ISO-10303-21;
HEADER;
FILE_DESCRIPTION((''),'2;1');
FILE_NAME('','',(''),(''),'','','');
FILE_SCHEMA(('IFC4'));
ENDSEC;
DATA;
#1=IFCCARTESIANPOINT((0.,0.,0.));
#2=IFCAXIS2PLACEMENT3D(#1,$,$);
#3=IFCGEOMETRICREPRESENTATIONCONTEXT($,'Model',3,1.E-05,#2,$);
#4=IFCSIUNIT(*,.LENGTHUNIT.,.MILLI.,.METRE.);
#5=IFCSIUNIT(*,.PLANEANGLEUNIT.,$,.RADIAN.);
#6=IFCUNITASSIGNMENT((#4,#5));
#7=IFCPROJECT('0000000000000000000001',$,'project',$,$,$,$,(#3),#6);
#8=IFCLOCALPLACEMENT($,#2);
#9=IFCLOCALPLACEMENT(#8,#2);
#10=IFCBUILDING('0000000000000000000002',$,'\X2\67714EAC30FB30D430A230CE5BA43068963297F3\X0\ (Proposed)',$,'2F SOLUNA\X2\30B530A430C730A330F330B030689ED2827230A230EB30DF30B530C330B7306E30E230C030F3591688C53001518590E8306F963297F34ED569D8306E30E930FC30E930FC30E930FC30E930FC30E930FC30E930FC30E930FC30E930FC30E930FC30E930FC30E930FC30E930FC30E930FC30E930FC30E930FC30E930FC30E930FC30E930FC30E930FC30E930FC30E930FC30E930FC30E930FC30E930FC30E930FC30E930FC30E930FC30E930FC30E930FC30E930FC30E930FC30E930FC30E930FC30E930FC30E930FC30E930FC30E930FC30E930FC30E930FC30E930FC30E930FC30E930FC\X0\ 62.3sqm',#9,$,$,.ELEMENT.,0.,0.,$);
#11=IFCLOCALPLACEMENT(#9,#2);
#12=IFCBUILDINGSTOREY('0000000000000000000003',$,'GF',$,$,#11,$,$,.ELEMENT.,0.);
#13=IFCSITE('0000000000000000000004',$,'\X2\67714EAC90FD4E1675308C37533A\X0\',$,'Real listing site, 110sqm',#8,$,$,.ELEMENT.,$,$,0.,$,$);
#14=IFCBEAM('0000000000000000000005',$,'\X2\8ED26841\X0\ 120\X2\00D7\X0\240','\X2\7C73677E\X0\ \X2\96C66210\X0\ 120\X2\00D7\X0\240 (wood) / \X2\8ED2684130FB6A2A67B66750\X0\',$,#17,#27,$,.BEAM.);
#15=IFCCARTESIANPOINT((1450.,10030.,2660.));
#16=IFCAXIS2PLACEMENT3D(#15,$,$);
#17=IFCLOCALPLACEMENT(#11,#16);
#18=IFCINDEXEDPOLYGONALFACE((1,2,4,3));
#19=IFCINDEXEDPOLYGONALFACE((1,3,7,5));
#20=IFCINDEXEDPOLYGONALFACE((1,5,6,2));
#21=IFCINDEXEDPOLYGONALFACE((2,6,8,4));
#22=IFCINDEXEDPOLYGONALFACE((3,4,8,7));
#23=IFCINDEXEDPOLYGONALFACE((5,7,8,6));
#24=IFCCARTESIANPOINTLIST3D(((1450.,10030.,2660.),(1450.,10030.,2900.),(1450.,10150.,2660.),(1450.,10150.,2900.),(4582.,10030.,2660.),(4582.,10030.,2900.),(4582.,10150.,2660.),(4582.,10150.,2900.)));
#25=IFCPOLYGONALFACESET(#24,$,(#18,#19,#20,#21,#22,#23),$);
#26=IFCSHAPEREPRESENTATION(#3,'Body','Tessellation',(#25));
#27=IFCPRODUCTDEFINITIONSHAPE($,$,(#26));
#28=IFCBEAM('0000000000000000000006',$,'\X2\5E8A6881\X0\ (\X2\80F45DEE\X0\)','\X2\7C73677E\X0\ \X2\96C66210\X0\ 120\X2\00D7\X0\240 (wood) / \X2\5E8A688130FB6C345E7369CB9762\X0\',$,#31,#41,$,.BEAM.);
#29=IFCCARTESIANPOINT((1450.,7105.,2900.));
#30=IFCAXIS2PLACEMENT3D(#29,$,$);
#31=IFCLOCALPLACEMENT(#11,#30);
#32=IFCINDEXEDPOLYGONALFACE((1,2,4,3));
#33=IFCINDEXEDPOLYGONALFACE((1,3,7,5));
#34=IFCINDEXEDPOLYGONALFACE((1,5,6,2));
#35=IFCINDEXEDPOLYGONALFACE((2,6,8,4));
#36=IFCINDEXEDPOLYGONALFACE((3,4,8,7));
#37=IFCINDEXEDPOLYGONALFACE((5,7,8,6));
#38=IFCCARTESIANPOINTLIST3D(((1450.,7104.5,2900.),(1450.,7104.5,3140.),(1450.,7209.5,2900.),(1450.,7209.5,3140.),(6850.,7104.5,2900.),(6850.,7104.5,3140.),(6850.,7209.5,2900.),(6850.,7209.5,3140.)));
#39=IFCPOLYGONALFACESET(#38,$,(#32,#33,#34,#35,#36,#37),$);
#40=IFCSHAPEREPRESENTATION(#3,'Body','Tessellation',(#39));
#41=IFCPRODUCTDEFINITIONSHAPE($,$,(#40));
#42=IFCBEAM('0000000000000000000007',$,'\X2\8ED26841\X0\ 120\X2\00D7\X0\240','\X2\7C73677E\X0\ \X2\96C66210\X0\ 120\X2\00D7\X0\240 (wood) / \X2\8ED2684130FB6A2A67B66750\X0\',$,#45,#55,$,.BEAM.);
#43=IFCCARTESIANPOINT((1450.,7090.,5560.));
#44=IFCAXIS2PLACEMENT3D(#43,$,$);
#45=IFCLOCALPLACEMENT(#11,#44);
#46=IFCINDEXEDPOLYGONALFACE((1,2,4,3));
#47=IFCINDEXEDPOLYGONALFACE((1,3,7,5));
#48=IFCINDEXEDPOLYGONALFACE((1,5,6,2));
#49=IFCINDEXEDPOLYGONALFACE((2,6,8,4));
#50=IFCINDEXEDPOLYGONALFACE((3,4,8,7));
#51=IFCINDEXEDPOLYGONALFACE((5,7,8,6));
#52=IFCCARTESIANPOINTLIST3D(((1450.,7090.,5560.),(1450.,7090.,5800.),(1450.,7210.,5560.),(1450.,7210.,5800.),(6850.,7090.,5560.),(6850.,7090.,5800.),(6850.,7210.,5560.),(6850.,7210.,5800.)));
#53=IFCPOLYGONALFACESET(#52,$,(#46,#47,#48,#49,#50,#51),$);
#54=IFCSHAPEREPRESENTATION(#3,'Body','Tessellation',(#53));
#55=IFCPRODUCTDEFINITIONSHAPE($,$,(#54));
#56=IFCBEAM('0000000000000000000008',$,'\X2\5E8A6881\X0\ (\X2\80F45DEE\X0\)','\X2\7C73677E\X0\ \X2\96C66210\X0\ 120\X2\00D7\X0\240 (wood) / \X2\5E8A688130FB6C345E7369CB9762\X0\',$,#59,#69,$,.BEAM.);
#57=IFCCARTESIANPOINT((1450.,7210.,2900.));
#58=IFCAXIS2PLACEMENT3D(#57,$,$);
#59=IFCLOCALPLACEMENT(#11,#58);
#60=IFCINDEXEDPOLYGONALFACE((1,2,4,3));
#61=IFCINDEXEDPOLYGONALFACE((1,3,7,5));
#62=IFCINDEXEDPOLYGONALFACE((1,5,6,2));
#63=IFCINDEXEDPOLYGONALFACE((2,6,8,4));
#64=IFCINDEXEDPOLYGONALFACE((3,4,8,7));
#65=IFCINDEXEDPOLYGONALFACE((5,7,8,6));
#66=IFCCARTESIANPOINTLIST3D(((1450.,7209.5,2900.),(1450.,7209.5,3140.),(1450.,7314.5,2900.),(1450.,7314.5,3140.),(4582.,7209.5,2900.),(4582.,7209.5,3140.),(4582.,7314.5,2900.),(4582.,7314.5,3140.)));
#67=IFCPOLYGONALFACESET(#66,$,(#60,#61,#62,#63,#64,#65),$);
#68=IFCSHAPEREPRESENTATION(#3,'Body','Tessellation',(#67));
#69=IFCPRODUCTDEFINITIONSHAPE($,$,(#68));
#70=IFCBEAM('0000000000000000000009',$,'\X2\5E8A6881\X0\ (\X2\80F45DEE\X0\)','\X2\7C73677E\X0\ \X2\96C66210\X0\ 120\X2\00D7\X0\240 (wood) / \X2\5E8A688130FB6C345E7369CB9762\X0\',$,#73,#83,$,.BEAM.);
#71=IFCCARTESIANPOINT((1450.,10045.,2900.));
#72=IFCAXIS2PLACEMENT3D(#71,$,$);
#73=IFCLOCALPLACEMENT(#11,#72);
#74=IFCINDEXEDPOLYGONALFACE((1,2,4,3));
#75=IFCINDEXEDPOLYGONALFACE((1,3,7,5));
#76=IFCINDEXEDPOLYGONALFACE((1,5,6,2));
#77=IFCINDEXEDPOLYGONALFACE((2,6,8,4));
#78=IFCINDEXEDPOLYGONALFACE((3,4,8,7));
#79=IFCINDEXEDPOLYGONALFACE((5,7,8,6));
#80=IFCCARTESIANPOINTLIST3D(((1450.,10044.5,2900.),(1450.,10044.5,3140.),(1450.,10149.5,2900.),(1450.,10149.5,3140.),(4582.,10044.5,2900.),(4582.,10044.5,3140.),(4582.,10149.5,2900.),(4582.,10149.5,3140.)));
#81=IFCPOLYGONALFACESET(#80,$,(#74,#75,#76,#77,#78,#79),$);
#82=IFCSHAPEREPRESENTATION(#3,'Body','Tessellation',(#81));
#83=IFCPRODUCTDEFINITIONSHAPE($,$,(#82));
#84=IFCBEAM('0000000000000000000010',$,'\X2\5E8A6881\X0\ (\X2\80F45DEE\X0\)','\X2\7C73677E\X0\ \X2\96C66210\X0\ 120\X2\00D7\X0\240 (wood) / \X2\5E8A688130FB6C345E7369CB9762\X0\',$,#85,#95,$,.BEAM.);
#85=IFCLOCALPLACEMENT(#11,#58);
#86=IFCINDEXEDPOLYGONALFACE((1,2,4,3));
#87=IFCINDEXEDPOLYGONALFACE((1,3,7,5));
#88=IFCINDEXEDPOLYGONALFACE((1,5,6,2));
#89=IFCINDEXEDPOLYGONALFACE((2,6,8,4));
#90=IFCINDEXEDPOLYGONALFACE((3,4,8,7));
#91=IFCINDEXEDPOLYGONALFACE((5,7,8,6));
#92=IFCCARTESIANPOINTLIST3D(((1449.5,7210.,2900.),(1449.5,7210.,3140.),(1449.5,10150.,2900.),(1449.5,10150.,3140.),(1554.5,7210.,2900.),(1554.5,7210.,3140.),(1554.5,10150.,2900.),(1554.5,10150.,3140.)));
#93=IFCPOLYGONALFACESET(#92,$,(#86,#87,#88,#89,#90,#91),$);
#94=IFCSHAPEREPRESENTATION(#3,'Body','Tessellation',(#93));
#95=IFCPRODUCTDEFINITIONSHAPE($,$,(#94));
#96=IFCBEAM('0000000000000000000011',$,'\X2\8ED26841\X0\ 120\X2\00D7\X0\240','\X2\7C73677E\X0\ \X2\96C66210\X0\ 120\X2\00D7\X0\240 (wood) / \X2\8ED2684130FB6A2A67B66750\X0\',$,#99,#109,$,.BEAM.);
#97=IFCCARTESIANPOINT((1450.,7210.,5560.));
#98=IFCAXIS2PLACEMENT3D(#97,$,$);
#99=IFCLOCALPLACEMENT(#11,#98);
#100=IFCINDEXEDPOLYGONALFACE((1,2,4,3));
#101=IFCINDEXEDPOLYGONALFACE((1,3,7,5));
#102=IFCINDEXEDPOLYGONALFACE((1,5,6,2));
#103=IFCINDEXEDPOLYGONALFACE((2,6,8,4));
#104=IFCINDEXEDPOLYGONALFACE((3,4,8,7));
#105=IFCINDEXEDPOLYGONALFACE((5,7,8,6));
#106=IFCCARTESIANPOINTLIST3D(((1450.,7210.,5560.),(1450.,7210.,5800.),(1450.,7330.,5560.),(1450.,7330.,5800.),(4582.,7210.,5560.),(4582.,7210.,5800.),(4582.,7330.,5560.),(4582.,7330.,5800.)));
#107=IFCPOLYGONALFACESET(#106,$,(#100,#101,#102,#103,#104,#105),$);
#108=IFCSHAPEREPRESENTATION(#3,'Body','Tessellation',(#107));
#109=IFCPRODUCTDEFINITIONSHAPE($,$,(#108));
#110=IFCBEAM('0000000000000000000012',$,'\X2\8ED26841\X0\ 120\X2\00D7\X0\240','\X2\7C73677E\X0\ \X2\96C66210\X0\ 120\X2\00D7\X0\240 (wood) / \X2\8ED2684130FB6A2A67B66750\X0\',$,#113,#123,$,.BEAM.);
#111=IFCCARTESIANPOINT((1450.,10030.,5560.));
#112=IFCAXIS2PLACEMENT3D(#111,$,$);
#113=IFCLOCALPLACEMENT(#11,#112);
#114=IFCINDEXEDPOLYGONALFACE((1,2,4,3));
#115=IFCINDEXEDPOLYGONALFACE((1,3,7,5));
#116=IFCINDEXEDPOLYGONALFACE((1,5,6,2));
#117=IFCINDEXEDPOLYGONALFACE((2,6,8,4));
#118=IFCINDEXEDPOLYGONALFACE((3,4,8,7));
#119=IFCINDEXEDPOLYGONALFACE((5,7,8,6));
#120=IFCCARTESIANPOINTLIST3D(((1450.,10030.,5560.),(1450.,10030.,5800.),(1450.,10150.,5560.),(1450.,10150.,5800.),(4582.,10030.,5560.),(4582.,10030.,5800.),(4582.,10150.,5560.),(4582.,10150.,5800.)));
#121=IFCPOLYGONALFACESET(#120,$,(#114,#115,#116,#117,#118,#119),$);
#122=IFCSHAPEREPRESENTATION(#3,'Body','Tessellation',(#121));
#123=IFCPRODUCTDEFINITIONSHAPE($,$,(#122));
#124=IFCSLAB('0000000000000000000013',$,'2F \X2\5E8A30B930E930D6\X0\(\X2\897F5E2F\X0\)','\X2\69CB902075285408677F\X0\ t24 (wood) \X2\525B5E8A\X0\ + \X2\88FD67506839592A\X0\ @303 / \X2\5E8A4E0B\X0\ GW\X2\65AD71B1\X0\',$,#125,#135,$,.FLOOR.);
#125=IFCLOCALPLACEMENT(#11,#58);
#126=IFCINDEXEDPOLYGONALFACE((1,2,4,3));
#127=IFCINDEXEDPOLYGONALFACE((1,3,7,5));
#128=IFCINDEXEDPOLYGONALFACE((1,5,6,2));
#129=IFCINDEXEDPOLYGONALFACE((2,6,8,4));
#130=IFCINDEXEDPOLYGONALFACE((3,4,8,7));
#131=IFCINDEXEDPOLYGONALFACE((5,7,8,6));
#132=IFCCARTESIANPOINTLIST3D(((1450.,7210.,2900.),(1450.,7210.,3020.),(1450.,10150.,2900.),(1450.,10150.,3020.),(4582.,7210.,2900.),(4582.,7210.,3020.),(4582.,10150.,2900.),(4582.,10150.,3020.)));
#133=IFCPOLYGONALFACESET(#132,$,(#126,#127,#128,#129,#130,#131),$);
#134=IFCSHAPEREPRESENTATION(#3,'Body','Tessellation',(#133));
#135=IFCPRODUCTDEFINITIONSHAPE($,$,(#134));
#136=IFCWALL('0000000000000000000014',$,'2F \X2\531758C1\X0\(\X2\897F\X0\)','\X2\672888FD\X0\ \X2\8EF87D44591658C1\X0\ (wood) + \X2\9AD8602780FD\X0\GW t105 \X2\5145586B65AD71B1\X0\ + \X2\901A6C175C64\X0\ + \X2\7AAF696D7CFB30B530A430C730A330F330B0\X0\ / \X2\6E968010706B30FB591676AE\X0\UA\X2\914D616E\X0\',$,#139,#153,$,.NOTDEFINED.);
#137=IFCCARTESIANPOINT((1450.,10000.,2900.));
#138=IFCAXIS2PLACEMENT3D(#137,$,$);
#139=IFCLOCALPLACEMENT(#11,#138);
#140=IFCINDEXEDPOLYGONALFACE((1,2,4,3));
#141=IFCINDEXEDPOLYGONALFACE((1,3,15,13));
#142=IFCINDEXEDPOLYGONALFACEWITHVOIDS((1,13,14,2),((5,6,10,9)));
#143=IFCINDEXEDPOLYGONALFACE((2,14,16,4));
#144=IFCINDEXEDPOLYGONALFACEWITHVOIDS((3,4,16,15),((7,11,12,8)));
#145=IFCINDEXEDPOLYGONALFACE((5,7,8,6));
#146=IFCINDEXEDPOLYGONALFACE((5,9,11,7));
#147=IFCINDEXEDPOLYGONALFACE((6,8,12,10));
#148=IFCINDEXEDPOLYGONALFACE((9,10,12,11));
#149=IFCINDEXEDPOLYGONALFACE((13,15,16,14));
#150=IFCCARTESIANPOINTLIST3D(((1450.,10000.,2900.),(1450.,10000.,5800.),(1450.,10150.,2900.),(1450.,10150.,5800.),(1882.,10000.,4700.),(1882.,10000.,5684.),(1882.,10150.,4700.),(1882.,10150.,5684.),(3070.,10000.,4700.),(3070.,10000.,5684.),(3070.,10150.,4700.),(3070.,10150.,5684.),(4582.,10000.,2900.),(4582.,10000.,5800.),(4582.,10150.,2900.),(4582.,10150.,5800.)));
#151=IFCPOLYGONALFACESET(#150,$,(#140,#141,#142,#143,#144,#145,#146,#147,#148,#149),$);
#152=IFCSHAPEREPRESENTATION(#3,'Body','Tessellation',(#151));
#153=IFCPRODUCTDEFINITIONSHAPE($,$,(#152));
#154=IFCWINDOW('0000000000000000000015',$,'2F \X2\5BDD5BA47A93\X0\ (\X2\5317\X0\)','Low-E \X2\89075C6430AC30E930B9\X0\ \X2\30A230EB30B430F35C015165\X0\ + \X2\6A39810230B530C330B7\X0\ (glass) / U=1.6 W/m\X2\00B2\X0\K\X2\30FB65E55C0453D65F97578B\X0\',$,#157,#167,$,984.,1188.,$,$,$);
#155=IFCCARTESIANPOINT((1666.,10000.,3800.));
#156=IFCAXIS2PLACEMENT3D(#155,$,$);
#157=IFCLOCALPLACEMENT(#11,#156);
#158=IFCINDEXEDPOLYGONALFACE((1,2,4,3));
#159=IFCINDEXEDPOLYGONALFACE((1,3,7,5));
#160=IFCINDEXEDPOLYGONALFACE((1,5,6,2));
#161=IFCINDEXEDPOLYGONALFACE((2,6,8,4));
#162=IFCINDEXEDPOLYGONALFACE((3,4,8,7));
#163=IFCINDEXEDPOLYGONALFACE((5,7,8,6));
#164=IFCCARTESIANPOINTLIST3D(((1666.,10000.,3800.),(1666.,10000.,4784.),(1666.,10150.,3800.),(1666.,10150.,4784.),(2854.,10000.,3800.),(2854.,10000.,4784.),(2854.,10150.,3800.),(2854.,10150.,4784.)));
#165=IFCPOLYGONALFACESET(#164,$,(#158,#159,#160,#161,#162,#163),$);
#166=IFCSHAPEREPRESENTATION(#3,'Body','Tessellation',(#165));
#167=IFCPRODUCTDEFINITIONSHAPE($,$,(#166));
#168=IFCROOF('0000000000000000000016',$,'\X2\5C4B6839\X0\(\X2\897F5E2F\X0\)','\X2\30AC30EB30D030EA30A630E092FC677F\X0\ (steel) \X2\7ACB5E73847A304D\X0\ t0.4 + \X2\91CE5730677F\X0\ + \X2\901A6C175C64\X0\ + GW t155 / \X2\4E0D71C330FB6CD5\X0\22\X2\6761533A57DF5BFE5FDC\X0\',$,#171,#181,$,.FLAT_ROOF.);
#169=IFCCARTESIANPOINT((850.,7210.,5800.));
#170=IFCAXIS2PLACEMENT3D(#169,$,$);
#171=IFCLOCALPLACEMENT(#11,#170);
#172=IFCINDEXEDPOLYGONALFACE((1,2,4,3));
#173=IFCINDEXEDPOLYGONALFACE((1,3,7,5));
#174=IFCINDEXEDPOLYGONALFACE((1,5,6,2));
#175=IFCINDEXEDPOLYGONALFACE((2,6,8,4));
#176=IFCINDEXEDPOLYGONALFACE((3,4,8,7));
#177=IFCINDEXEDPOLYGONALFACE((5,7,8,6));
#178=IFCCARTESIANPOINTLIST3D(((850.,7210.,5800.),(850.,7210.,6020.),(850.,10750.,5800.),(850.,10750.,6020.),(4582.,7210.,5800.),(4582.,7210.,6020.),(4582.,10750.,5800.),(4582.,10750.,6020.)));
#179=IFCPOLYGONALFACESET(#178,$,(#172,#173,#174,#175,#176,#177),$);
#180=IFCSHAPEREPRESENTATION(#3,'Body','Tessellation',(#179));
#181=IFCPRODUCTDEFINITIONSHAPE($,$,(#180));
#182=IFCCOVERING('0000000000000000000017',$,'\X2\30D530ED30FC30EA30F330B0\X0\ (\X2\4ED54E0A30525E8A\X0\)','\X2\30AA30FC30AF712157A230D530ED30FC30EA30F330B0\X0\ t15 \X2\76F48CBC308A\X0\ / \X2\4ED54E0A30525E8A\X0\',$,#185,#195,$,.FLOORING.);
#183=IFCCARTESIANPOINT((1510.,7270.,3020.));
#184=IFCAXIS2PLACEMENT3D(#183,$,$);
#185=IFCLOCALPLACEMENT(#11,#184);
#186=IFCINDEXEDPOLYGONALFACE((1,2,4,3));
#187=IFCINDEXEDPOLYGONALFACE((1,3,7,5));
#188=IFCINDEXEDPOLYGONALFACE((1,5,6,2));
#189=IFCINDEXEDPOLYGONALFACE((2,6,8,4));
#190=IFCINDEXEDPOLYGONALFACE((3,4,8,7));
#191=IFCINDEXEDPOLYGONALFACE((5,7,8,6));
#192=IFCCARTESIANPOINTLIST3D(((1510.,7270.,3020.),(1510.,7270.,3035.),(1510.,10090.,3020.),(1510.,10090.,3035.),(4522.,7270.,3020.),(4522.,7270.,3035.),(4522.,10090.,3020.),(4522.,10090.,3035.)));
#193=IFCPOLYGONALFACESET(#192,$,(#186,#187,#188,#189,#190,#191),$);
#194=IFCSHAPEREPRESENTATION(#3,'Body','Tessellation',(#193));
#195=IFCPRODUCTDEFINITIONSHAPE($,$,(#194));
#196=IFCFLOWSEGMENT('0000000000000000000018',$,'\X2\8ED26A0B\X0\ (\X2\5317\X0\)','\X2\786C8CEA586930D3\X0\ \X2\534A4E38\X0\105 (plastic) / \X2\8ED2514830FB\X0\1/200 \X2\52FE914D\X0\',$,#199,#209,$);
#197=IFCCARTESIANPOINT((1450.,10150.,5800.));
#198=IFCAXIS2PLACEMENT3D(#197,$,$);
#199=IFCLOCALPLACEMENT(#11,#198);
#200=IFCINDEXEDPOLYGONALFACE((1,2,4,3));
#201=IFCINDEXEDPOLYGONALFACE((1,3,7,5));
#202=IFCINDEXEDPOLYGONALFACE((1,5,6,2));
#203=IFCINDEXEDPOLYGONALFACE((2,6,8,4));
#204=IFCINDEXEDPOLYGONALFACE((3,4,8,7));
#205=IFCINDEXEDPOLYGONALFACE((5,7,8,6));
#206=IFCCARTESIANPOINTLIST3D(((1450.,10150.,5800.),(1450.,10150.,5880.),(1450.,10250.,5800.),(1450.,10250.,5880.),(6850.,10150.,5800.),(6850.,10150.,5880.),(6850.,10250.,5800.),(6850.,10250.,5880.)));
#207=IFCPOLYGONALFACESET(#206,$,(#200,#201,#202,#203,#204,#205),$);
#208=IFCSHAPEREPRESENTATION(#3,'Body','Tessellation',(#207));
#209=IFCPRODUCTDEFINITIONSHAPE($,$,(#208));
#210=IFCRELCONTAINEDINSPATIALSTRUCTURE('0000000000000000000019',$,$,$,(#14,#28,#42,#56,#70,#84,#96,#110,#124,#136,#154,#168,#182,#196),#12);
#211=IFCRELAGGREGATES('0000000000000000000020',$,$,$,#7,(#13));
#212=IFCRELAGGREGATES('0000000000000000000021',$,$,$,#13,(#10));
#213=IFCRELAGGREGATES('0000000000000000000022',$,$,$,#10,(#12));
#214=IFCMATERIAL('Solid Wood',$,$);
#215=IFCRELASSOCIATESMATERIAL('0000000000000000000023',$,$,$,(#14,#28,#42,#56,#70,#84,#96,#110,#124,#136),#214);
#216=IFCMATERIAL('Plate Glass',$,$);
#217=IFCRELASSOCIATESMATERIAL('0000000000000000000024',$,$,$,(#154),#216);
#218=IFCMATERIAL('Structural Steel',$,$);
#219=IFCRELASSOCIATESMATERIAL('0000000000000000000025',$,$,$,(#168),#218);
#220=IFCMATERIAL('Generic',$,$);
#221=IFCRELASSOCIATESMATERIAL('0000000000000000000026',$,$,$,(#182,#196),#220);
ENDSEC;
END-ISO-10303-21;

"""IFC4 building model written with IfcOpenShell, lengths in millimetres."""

from ifc_helpers import new_model, si_unit, frame, frame_2d, origin, place, context, project, spatial, rectangle, extrude, material, element, fill, save


model = new_model("IFC4")

# Units and contexts
model_context = context("Model", 3, precision=1e-05, world=origin())
ifc_project = project(units=[si_unit("LENGTHUNIT", "METRE", prefix="MILLI"), si_unit("PLANEANGLEUNIT", "RADIAN")], contexts=[model_context])

# Site, building, storey
site_placement = place(None, origin())
site = spatial("IfcSite", under=ifc_project, at=site_placement, Name="東京都世田谷区", ObjectType="Real listing site, 110sqm", CompositionType="ELEMENT", RefElevation=0.0)
building_placement = place(site_placement, origin())
building = spatial("IfcBuilding", under=site, at=building_placement, Name="東京・ピアノ室と防音 (Proposed)", ObjectType="2F SOLUNAサイディングと黒色アルミサッシのモダン外装、内部は防音仕様のラーラーラーラーラーラーラーラーラーラーラーラーラーラーラーラーラーラーラーラーラーラーラーラーラーラーラーラーラーラーラーラーラーラーラーラーラーラーラーラーラーラー 62.3sqm", CompositionType="ELEMENT", ElevationOfRefHeight=0.0, ElevationOfTerrain=0.0)
storey_placement = place(building_placement, origin())
storey = spatial("IfcBuildingStorey", under=building, at=storey_placement, Name="GF", CompositionType="ELEMENT", Elevation=0.0)

# Shared definitions
ifc_material_1 = material(Name="Solid Wood")

# Beams
beam_1_placement = place(storey_placement, frame((1450.0, 10030.0, 2660.0)))
element("IfcBeam", 1, at=beam_1_placement, inside=storey, material=ifc_material_1, Name="軒桁 120×240", Description="米松 集成 120×240 (wood) / 軒桁・横架材", PredefinedType="BEAM", context=model_context, shape_type="SweptSolid", body=[
    extrude(rectangle(XDim=3132.0, YDim=120.0, at=frame_2d((1566.0, 60.0))), frame((1450.0, 10030.0, 2660.0)), (0.0, 0.0, 1.0), 240.0),
])
beam_2_placement = place(storey_placement, frame((1450.0, 7105.0, 2900.0)))
element("IfcBeam", 2, at=beam_2_placement, inside=storey, material=ifc_material_1, Name="床梁 (胴差)", Description="米松 集成 120×240 (wood) / 床梁・水平構面", PredefinedType="BEAM", context=model_context, shape_type="SweptSolid", body=[
    extrude(rectangle(XDim=5400.0, YDim=105.0, at=frame_2d((2700.0, 52.0))), frame((1450.0, 7105.0, 2900.0)), (0.0, 0.0, 1.0), 240.0),
])
beam_3_placement = place(storey_placement, frame((1450.0, 7090.0, 5560.0)))
element("IfcBeam", 3, at=beam_3_placement, inside=storey, material=ifc_material_1, Name="軒桁 120×240", Description="米松 集成 120×240 (wood) / 軒桁・横架材", PredefinedType="BEAM", context=model_context, shape_type="SweptSolid", body=[
    extrude(rectangle(XDim=5400.0, YDim=120.0, at=frame_2d((2700.0, 60.0))), frame((1450.0, 7090.0, 5560.0)), (0.0, 0.0, 1.0), 240.0),
])
beam_4_placement = place(storey_placement, frame((1450.0, 7210.0, 2900.0)))
element("IfcBeam", 4, at=beam_4_placement, inside=storey, material=ifc_material_1, Name="床梁 (胴差)", Description="米松 集成 120×240 (wood) / 床梁・水平構面", PredefinedType="BEAM", context=model_context, shape_type="SweptSolid", body=[
    extrude(rectangle(XDim=3132.0, YDim=105.0, at=frame_2d((1566.0, 52.0))), frame((1450.0, 7210.0, 2900.0)), (0.0, 0.0, 1.0), 240.0),
])
beam_5_placement = place(storey_placement, frame((1450.0, 10045.0, 2900.0)))
element("IfcBeam", 5, at=beam_5_placement, inside=storey, material=ifc_material_1, Name="床梁 (胴差)", Description="米松 集成 120×240 (wood) / 床梁・水平構面", PredefinedType="BEAM", context=model_context, shape_type="SweptSolid", body=[
    extrude(rectangle(XDim=3132.0, YDim=105.0, at=frame_2d((1566.0, 52.0))), frame((1450.0, 10045.0, 2900.0)), (0.0, 0.0, 1.0), 240.0),
])
beam_6_placement = place(storey_placement, frame((1450.0, 7210.0, 2900.0)))
element("IfcBeam", 6, at=beam_6_placement, inside=storey, material=ifc_material_1, Name="床梁 (胴差)", Description="米松 集成 120×240 (wood) / 床梁・水平構面", PredefinedType="BEAM", context=model_context, shape_type="SweptSolid", body=[
    extrude(rectangle(XDim=105.0, YDim=2940.0, at=frame_2d((52.0, 1470.0))), frame((1450.0, 7210.0, 2900.0)), (0.0, 0.0, 1.0), 240.0),
])
beam_7_placement = place(storey_placement, frame((1450.0, 7210.0, 5560.0)))
element("IfcBeam", 7, at=beam_7_placement, inside=storey, material=ifc_material_1, Name="軒桁 120×240", Description="米松 集成 120×240 (wood) / 軒桁・横架材", PredefinedType="BEAM", context=model_context, shape_type="SweptSolid", body=[
    extrude(rectangle(XDim=3132.0, YDim=120.0, at=frame_2d((1566.0, 60.0))), frame((1450.0, 7210.0, 5560.0)), (0.0, 0.0, 1.0), 240.0),
])
beam_8_placement = place(storey_placement, frame((1450.0, 10030.0, 5560.0)))
element("IfcBeam", 8, at=beam_8_placement, inside=storey, material=ifc_material_1, Name="軒桁 120×240", Description="米松 集成 120×240 (wood) / 軒桁・横架材", PredefinedType="BEAM", context=model_context, shape_type="SweptSolid", body=[
    extrude(rectangle(XDim=3132.0, YDim=120.0, at=frame_2d((1566.0, 60.0))), frame((1450.0, 10030.0, 5560.0)), (0.0, 0.0, 1.0), 240.0),
])

# Slab
slab_placement = place(storey_placement, frame((1450.0, 7210.0, 2900.0)))
element("IfcSlab", 9, at=slab_placement, inside=storey, material=ifc_material_1, Name="2F 床スラブ(西帯)", Description="構造用合板 t24 (wood) 剛床 + 製材根太 @303 / 床下 GW断熱", PredefinedType="FLOOR", context=model_context, shape_type="SweptSolid", body=[
    extrude(rectangle(XDim=3132.0, YDim=2940.0, at=frame_2d((1566.0, 1470.0))), frame((1450.0, 7210.0, 2900.0)), (0.0, 0.0, 1.0), 120.0),
])

# Wall, opening, window
wall_1_placement = place(storey_placement, frame((1450.0, 10000.0, 2900.0)))
wall_1 = element("IfcWall", 10, at=wall_1_placement, inside=storey, material=ifc_material_1, Name="2F 北壁(西)", Description="木製 軸組外壁 (wood) + 高性能GW t105 充填断熱 + 通気層 + 窯業系サイディング / 準耐火・外皮UA配慮", PredefinedType="NOTDEFINED", context=model_context, shape_type="SweptSolid", body=[
    extrude(rectangle(XDim=3132.0, YDim=150.0, at=frame_2d((1566.0, 75.0))), frame((1450.0, 10000.0, 2900.0)), (0.0, 0.0, 1.0), 2900.0),
])
opening_placement = place(storey_placement, frame((1666.0, 10000.0, 3800.0)))
opening = element("IfcOpeningElement", 11, at=opening_placement, cuts=wall_1, PredefinedType="NOTDEFINED", context=model_context, shape_type="SweptSolid", body=[
    extrude(rectangle(XDim=1188.0, YDim=150.0, at=frame_2d((594.0, 75.0))), frame((1666.0, 10000.0, 3800.0)), (0.0, 0.0, 1.0), 984.0),
])
ifc_material_2 = material(Name="Plate Glass")
window_placement = place(storey_placement, frame((1666.0, 10000.0, 3800.0)))
window = element("IfcWindow", 12, at=window_placement, inside=storey, material=ifc_material_2, Name="2F 寝室窓 (北)", Description="Low-E 複層ガラス アルゴン封入 + 樹脂サッシ (glass) / U=1.6 W/m²K・日射取得型", OverallHeight=984.0, OverallWidth=1188.0, context=model_context, shape_type="SweptSolid", body=[
    extrude(rectangle(XDim=1188.0, YDim=150.0, at=frame_2d((594.0, 75.0))), frame((1666.0, 10000.0, 3800.0)), (0.0, 0.0, 1.0), 984.0),
])
fill(opening, window)

# Roof
ifc_material_3 = material(Name="Structural Steel")
for number, where, name in (
    (13, (850.0, 7210.0, 5800.0), "屋根(西帯)"),
):
    element("IfcRoof", number, at=place(storey_placement, frame(where)), inside=storey, material=ifc_material_3, Name=name, Description="ガルバリウム鋼板 (steel) 立平葺き t0.4 + 野地板 + 通気層 + GW t155 / 不燃・法22条区域対応", PredefinedType="FLAT_ROOF", context=model_context, shape_type="SweptSolid", body=[
        extrude(rectangle(XDim=3732.0, YDim=3540.0, at=frame_2d((1866.0, 1770.0))), frame((850.0, 7210.0, 5800.0)), (0.0, 0.0, 1.0), 220.0),
    ])

# Covering
ifc_material_4 = material(Name="Generic")
covering_placement = place(storey_placement, frame((1510.0, 7270.0, 3020.0)))
element("IfcCovering", 14, at=covering_placement, inside=storey, material=ifc_material_4, Name="フローリング (仕上げ床)", Description="オーク無垢フローリング t15 直貼り / 仕上げ床", PredefinedType="FLOORING", context=model_context, shape_type="SweptSolid", body=[
    extrude(rectangle(XDim=3012.0, YDim=2820.0, at=frame_2d((1506.0, 1410.0))), frame((1510.0, 7270.0, 3020.0)), (0.0, 0.0, 1.0), 15.0),
])

# Flow segment
flow_segment_placement = place(storey_placement, frame((1450.0, 10150.0, 5800.0)))
element("IfcFlowSegment", 15, at=flow_segment_placement, inside=storey, material=ifc_material_4, Name="軒樋 (北)", Description="硬質塩ビ 半丸105 (plastic) / 軒先・1/200 勾配", context=model_context, shape_type="SweptSolid", body=[
    extrude(rectangle(XDim=5400.0, YDim=100.0, at=frame_2d((2700.0, 50.0))), frame((1450.0, 10150.0, 5800.0)), (0.0, 0.0, 1.0), 80.0),
])

save(model, "model.ifc")
